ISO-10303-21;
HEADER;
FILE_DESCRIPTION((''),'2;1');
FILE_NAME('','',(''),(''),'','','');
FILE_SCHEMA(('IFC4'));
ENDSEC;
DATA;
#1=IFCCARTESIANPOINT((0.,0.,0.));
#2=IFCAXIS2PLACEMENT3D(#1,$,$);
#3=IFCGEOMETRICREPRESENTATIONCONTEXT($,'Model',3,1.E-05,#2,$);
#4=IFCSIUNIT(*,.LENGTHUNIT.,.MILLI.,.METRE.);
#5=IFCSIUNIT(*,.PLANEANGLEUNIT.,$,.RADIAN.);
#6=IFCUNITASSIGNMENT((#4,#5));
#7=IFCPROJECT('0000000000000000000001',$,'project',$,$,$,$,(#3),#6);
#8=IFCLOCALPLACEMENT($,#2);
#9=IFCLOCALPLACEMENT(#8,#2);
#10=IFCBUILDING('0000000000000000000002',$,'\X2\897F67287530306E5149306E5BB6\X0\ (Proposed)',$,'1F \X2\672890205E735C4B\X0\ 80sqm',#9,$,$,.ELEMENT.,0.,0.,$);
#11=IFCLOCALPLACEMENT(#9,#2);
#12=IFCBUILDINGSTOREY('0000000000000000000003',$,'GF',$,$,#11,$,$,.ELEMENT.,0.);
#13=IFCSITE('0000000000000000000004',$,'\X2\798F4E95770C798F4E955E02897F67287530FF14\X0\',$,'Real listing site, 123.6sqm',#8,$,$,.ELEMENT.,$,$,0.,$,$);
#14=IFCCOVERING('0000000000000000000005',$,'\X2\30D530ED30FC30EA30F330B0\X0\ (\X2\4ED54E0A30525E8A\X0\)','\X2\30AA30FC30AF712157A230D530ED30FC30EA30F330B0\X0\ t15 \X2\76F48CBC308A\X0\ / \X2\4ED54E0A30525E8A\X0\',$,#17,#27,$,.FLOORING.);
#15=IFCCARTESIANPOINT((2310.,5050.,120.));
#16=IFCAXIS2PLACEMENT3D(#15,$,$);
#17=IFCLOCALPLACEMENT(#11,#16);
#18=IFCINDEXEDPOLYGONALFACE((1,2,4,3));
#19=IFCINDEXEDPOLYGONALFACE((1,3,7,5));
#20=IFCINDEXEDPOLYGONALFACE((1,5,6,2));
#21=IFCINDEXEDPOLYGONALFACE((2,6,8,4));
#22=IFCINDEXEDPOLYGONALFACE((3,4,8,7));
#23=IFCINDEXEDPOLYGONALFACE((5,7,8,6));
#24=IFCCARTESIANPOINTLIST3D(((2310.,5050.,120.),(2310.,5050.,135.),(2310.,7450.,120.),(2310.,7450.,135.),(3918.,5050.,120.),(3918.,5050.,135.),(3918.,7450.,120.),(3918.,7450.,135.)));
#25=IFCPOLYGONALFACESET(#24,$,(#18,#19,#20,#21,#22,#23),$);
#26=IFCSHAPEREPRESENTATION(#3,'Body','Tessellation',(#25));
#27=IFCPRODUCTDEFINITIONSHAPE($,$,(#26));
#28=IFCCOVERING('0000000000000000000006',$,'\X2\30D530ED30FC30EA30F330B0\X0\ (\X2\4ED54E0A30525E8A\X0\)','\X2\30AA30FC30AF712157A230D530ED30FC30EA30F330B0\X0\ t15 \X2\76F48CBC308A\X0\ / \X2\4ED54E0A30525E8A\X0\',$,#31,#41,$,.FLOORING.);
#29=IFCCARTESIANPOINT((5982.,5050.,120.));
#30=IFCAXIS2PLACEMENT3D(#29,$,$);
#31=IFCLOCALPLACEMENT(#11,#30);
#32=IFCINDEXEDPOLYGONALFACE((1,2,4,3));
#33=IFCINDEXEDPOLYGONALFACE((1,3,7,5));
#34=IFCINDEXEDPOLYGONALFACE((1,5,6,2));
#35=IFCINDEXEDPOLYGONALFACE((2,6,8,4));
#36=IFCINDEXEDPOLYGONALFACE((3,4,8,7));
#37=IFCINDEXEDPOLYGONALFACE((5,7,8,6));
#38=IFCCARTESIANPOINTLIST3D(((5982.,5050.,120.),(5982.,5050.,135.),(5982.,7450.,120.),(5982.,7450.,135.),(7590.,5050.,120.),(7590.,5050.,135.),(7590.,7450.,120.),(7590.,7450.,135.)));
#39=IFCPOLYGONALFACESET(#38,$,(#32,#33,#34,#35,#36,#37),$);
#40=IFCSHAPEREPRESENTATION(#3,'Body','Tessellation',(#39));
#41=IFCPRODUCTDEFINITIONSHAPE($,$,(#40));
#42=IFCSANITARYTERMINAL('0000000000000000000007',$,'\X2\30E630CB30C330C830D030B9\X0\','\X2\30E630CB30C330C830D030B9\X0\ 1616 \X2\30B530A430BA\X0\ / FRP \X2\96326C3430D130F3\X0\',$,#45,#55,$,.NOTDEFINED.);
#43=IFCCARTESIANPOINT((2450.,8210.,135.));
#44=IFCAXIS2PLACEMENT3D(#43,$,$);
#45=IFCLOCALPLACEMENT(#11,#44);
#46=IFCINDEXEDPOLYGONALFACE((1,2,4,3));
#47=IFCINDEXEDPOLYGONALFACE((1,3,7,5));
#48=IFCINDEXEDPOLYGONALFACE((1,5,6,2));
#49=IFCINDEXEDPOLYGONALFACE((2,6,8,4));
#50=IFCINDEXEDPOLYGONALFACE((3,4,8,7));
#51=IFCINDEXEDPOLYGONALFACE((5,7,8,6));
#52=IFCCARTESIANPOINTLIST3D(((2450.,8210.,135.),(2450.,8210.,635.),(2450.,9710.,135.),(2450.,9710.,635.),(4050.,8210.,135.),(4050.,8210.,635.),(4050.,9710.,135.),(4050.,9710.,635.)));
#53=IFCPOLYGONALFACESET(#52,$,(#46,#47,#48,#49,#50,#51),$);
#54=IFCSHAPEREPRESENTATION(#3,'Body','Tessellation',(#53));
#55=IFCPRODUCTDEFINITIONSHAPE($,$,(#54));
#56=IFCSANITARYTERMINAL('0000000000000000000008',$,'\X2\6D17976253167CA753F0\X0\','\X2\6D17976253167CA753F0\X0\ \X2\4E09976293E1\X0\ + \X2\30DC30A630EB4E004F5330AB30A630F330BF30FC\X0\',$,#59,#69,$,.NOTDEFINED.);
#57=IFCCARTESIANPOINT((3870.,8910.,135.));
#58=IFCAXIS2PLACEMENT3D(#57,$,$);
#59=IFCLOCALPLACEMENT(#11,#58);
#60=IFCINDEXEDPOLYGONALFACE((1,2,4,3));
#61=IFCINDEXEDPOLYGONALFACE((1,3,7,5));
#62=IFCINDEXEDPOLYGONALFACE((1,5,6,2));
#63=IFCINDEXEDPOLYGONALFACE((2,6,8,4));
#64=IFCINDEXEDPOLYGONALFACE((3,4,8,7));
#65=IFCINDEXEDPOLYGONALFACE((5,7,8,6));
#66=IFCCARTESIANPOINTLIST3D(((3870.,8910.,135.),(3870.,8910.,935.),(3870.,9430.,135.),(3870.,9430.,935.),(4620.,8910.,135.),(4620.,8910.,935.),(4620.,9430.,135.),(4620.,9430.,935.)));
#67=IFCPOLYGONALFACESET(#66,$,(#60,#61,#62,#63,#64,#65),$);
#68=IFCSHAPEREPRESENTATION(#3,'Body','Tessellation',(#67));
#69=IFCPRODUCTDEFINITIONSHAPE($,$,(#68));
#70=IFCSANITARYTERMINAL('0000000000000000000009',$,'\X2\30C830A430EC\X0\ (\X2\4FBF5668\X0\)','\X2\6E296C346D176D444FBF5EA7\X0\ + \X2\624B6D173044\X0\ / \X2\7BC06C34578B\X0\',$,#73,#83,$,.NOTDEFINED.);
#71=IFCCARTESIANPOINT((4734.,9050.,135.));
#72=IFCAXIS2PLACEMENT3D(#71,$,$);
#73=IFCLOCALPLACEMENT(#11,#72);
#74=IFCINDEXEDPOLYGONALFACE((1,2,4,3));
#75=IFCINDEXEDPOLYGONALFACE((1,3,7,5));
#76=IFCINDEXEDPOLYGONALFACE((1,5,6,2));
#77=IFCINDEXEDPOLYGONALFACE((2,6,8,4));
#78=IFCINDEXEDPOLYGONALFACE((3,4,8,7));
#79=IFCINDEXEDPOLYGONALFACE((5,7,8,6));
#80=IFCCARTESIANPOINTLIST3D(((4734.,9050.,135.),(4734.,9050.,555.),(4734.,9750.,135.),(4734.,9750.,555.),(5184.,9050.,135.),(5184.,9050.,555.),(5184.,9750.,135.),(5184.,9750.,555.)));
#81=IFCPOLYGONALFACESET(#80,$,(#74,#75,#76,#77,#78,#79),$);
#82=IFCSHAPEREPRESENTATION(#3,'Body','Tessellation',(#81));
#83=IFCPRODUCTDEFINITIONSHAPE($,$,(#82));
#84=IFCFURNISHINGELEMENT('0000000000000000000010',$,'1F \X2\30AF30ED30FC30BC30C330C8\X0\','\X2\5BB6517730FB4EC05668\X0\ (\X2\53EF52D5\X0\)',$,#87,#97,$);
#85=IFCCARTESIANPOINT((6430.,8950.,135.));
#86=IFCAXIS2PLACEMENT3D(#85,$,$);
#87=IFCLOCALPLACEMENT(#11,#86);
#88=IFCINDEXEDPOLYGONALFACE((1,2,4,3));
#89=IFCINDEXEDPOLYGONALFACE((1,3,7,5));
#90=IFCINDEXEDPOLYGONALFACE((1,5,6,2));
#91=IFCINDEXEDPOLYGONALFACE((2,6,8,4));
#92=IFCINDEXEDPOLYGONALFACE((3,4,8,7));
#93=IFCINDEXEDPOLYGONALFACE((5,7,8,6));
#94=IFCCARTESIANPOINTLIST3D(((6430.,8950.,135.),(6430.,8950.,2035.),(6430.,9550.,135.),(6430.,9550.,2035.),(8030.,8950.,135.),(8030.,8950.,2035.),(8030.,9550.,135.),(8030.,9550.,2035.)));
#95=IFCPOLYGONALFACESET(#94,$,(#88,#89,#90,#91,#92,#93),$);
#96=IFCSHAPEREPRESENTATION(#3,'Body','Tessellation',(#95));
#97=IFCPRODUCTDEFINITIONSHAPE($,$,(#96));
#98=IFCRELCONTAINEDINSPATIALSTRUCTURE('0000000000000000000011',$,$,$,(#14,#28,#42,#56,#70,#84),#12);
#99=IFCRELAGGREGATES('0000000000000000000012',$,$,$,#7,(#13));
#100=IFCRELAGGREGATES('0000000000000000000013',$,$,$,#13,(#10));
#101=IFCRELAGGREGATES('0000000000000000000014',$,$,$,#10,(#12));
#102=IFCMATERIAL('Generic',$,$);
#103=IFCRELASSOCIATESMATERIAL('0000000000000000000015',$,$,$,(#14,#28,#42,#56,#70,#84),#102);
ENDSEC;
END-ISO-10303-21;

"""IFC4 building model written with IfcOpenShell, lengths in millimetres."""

from ifc_helpers import new_model, si_unit, frame, frame_2d, origin, place, context, project, spatial, rectangle, extrude, material, element, save


model = new_model("IFC4")

# Units and contexts
model_context = context("Model", 3, precision=1e-05, world=origin())
ifc_project = project(units=[si_unit("LENGTHUNIT", "METRE", prefix="MILLI"), si_unit("PLANEANGLEUNIT", "RADIAN")], contexts=[model_context])

# Site, building, storey
site_placement = place(None, origin())
site = spatial("IfcSite", under=ifc_project, at=site_placement, Name="福井県福井市西木田４", ObjectType="Real listing site, 123.6sqm", CompositionType="ELEMENT", RefElevation=0.0)
building_placement = place(site_placement, origin())
building = spatial("IfcBuilding", under=site, at=building_placement, Name="西木田の光の家 (Proposed)", ObjectType="1F 木造平屋 80sqm", CompositionType="ELEMENT", ElevationOfRefHeight=0.0, ElevationOfTerrain=0.0)
storey_placement = place(building_placement, origin())
storey = spatial("IfcBuildingStorey", under=building, at=storey_placement, Name="GF", CompositionType="ELEMENT", Elevation=0.0)

# Coverings
ifc_material_1 = material(Name="Generic")
covering_1_placement = place(storey_placement, frame((2310.0, 5050.0, 120.0)))
element("IfcCovering", 1, at=covering_1_placement, inside=storey, material=ifc_material_1, Name="フローリング (仕上げ床)", Description="オーク無垢フローリング t15 直貼り / 仕上げ床", PredefinedType="FLOORING", context=model_context, shape_type="SweptSolid", body=[
    extrude(rectangle(XDim=1608.0, YDim=2400.0, at=frame_2d((804.0, 1200.0))), frame((2310.0, 5050.0, 120.0)), (0.0, 0.0, 1.0), 15.0),
])
covering_2_placement = place(storey_placement, frame((5982.0, 5050.0, 120.0)))
element("IfcCovering", 2, at=covering_2_placement, inside=storey, material=ifc_material_1, Name="フローリング (仕上げ床)", Description="オーク無垢フローリング t15 直貼り / 仕上げ床", PredefinedType="FLOORING", context=model_context, shape_type="SweptSolid", body=[
    extrude(rectangle(XDim=1608.0, YDim=2400.0, at=frame_2d((804.0, 1200.0))), frame((5982.0, 5050.0, 120.0)), (0.0, 0.0, 1.0), 15.0),
])

# Sanitary terminals
sanitary_terminal_1_placement = place(storey_placement, frame((2450.0, 8210.0, 135.0)))
element("IfcSanitaryTerminal", 3, at=sanitary_terminal_1_placement, inside=storey, material=ifc_material_1, Name="ユニットバス", Description="ユニットバス 1616 サイズ / FRP 防水パン", PredefinedType="NOTDEFINED", context=model_context, shape_type="SweptSolid", body=[
    extrude(rectangle(XDim=1600.0, YDim=1500.0, at=frame_2d((800.0, 750.0))), frame((2450.0, 8210.0, 135.0)), (0.0, 0.0, 1.0), 500.0),
])
sanitary_terminal_2_placement = place(storey_placement, frame((3870.0, 8910.0, 135.0)))
element("IfcSanitaryTerminal", 4, at=sanitary_terminal_2_placement, inside=storey, material=ifc_material_1, Name="洗面化粧台", Description="洗面化粧台 三面鏡 + ボウル一体カウンター", PredefinedType="NOTDEFINED", context=model_context, shape_type="SweptSolid", body=[
    extrude(rectangle(XDim=750.0, YDim=520.0, at=frame_2d((375.0, 260.0))), frame((3870.0, 8910.0, 135.0)), (0.0, 0.0, 1.0), 800.0),
])
sanitary_terminal_3_placement = place(storey_placement, frame((4734.0, 9050.0, 135.0)))
element("IfcSanitaryTerminal", 5, at=sanitary_terminal_3_placement, inside=storey, material=ifc_material_1, Name="トイレ (便器)", Description="温水洗浄便座 + 手洗い / 節水型", PredefinedType="NOTDEFINED", context=model_context, shape_type="SweptSolid", body=[
    extrude(rectangle(XDim=450.0, YDim=700.0, at=frame_2d((225.0, 350.0))), frame((4734.0, 9050.0, 135.0)), (0.0, 0.0, 1.0), 420.0),
])

# Furnishing element
furnishing_placement = place(storey_placement, frame((6430.0, 8950.0, 135.0)))
element("IfcFurnishingElement", 6, at=furnishing_placement, inside=storey, material=ifc_material_1, Name="1F クローゼット", Description="家具・什器 (可動)", context=model_context, shape_type="SweptSolid", body=[
    extrude(rectangle(XDim=1600.0, YDim=600.0, at=frame_2d((800.0, 300.0))), frame((6430.0, 8950.0, 135.0)), (0.0, 0.0, 1.0), 1900.0),
])

save(model, "model.ifc")
